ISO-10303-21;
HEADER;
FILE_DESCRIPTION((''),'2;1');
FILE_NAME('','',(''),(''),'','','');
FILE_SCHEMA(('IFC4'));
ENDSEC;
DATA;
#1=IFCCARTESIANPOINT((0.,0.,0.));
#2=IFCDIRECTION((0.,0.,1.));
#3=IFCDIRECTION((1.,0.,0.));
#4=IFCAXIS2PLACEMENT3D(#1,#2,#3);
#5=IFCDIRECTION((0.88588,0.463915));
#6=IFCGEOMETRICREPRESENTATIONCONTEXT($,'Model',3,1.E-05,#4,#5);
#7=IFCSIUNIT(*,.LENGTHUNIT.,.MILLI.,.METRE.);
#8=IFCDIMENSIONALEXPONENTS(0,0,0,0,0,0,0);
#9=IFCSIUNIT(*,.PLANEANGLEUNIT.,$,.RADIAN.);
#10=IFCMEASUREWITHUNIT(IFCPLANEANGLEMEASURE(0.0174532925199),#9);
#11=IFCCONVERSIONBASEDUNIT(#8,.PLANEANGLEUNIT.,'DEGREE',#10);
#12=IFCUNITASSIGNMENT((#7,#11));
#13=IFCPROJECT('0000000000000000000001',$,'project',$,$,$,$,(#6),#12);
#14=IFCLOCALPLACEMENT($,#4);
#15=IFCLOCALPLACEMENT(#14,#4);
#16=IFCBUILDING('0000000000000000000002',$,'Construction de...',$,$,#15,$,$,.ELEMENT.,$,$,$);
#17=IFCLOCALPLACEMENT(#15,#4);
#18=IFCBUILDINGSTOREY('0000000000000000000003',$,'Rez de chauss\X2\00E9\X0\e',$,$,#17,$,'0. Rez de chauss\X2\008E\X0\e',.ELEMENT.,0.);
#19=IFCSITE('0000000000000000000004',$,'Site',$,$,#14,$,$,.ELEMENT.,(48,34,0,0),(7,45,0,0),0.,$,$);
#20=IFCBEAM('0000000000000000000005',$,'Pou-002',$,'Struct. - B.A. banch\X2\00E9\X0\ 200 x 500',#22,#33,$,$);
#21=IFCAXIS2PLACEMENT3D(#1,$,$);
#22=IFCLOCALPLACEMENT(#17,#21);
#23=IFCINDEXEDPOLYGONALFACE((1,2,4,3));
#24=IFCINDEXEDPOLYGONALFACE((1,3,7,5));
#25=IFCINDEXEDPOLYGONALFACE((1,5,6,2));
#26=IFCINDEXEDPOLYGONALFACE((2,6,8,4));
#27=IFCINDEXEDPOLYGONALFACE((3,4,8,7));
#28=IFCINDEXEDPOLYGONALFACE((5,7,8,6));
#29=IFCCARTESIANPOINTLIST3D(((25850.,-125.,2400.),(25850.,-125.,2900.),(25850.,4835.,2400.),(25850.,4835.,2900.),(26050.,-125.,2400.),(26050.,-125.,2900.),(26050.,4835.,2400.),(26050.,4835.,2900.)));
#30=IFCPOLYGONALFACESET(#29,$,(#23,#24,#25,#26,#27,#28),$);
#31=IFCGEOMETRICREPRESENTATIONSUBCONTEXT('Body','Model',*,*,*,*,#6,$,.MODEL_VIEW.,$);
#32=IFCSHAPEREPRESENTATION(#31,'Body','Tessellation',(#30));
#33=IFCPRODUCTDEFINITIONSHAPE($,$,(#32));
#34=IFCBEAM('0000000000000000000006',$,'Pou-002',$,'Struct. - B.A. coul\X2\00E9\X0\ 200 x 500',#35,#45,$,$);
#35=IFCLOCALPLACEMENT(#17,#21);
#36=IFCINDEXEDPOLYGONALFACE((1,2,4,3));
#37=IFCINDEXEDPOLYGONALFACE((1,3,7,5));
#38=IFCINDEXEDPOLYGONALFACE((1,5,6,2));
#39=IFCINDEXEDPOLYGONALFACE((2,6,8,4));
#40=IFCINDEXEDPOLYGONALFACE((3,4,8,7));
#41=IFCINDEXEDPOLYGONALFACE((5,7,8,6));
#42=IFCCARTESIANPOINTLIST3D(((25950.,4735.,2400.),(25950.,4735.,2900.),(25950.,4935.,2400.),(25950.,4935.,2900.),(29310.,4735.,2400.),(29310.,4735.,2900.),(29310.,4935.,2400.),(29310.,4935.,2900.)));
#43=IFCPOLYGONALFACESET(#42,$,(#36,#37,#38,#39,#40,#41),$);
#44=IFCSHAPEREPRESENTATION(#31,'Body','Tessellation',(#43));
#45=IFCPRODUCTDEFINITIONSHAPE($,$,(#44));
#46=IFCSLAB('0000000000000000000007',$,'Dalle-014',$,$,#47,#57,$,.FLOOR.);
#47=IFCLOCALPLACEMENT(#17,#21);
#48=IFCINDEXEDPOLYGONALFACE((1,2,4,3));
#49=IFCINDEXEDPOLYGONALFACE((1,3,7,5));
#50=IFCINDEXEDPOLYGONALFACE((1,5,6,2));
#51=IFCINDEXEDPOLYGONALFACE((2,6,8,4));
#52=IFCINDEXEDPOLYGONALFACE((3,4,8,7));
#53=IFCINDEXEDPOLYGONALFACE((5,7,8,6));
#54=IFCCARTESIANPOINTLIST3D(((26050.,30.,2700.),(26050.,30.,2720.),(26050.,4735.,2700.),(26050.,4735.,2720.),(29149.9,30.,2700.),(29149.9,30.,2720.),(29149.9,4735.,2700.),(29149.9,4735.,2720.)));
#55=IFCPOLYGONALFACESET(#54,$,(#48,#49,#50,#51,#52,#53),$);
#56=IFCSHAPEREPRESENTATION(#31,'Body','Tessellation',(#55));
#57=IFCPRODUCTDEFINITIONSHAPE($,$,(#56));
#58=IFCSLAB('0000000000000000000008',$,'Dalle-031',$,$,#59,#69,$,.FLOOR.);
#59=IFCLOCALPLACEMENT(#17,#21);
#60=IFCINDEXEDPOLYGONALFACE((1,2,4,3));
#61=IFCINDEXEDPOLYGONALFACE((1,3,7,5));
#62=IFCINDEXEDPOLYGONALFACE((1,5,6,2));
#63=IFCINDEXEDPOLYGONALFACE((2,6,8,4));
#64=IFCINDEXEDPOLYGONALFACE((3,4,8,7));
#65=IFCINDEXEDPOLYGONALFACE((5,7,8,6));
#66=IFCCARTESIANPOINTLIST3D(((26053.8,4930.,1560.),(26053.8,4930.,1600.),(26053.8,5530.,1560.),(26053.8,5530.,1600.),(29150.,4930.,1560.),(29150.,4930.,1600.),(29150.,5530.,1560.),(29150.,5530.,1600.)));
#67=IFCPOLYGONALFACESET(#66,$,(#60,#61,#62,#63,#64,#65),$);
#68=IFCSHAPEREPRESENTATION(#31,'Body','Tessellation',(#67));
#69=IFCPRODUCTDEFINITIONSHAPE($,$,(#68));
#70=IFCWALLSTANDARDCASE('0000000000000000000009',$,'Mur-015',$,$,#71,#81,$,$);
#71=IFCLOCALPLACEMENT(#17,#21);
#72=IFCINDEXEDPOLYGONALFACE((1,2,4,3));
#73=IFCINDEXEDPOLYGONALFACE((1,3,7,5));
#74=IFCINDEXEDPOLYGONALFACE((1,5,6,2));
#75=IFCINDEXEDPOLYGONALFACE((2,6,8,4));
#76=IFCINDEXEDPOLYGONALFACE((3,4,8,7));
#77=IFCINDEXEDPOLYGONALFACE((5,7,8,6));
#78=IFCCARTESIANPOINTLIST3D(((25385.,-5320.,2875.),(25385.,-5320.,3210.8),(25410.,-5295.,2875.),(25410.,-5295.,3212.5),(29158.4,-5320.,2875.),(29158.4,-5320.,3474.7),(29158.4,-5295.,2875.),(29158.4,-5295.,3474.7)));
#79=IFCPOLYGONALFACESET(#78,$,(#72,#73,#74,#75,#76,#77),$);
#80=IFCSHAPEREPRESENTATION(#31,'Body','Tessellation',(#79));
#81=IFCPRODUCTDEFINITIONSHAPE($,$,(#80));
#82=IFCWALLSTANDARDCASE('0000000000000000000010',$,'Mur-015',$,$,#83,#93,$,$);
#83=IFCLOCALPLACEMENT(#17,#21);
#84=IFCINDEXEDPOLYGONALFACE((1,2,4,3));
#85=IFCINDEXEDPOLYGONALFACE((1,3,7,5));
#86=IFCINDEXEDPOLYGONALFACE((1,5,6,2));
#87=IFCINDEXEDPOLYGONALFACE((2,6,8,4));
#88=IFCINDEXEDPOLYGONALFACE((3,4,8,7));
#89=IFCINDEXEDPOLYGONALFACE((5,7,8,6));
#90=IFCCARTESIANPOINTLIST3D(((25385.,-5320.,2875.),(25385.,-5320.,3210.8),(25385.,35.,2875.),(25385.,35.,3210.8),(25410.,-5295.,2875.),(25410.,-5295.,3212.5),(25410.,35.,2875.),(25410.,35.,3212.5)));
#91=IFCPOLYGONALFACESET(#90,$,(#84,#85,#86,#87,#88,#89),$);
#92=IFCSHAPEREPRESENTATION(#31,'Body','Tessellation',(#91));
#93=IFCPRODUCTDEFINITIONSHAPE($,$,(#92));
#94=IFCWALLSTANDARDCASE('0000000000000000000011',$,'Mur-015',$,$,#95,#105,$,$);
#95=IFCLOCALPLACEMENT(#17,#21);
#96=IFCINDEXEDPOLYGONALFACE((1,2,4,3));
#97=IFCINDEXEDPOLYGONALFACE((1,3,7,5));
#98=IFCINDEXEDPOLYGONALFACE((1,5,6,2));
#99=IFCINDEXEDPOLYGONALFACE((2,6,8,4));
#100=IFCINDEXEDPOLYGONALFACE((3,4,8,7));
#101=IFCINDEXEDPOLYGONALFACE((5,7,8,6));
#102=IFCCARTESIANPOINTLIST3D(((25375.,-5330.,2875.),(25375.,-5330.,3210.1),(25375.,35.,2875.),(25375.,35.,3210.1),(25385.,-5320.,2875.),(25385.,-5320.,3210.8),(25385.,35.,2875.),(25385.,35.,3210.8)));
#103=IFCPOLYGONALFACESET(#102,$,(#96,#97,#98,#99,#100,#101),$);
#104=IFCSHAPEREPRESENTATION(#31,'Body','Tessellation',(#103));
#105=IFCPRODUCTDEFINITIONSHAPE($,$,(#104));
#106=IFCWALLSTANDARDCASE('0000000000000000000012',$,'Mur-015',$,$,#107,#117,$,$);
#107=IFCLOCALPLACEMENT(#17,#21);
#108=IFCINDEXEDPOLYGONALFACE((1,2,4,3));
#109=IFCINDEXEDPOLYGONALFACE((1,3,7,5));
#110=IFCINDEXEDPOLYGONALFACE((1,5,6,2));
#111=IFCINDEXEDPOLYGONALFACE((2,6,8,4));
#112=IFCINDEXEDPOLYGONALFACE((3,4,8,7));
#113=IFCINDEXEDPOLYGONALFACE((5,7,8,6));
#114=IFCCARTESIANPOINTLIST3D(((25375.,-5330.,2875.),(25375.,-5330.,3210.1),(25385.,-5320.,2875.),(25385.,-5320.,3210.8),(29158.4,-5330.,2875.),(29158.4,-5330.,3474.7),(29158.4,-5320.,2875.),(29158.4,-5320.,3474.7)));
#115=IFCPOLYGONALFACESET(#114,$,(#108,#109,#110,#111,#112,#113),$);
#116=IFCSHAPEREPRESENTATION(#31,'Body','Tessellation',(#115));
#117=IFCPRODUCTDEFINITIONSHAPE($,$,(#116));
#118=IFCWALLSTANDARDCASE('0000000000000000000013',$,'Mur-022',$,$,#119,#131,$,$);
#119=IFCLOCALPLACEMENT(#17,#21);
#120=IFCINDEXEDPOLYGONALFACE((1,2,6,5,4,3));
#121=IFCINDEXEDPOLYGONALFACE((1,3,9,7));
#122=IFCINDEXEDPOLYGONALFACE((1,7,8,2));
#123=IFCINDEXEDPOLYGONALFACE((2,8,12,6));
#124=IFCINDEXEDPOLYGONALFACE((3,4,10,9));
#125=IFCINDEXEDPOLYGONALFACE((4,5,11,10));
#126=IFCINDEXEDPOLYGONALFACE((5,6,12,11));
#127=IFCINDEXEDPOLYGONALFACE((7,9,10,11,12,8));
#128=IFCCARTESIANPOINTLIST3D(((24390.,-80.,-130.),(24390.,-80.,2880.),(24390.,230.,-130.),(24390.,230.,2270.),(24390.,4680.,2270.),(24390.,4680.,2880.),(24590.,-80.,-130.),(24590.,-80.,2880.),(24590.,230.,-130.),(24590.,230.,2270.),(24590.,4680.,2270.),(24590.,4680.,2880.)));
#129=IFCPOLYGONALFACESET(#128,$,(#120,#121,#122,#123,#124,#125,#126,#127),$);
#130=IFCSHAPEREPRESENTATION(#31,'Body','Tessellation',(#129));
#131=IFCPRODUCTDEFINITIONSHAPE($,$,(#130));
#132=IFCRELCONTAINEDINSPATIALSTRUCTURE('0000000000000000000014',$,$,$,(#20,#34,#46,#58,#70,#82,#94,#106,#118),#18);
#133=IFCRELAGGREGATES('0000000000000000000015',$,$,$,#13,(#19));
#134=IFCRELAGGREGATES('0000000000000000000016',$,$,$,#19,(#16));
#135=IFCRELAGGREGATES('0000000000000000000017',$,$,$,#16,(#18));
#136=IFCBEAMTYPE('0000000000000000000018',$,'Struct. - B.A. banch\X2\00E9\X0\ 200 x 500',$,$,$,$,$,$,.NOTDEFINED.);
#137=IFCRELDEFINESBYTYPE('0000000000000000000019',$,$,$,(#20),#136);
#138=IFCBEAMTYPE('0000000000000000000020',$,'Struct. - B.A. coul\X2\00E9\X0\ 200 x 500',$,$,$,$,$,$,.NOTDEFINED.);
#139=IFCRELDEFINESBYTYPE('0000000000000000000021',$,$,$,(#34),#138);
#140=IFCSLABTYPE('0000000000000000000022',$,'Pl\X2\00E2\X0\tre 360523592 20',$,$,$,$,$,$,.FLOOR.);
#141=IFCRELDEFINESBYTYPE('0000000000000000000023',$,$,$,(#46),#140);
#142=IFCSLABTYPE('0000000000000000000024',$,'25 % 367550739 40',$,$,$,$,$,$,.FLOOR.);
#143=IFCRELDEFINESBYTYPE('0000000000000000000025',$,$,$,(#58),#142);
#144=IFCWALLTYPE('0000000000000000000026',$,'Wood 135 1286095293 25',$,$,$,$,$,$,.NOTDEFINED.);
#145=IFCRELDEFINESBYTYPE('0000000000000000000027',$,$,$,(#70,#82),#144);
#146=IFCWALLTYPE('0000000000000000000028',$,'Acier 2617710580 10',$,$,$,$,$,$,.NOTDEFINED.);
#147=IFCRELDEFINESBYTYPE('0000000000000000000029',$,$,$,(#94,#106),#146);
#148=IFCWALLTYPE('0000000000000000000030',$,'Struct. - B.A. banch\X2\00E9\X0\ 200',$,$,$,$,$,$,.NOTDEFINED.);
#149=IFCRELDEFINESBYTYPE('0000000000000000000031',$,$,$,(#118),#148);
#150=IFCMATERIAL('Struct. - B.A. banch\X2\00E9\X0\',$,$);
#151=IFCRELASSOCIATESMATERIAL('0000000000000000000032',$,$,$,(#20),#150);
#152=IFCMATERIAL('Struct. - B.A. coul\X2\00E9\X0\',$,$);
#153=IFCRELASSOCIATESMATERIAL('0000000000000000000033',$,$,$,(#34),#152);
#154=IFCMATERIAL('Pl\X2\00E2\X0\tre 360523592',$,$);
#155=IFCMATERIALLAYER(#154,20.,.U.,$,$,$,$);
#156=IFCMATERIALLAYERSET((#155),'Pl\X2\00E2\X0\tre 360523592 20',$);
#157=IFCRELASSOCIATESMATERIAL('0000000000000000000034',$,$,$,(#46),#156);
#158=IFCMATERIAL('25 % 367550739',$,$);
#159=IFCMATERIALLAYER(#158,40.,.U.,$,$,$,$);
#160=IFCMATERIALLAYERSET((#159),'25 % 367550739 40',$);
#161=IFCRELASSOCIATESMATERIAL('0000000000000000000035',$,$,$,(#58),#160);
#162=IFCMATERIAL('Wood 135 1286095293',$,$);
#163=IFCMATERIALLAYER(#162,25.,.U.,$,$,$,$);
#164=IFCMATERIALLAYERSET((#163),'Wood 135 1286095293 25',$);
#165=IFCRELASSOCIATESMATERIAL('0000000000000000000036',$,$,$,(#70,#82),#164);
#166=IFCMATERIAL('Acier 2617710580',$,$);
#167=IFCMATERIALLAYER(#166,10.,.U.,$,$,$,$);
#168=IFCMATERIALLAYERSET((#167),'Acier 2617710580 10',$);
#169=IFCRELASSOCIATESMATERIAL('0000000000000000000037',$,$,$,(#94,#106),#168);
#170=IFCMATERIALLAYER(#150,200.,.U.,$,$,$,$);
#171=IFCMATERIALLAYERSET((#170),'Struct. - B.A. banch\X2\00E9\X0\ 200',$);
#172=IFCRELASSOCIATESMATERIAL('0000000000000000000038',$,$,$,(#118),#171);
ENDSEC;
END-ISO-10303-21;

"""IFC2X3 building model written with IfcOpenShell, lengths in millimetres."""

from ifc_helpers import new_model, entity, si_unit, converted_unit, direction, frame, frame_2d, origin_with_axes, origin_2d_with_axis, place, context, subcontext, project, spatial, polyline, rectangle, outline, extrude, clip, halfspace, material, layer, layer_set, layer_usage, type_object, element, save


model = new_model("IFC2X3")

# Units and contexts
model_context = context("Model", 3, precision=1e-05, world=origin_with_axes(), true_north=direction((0.88588, 0.463915)))
body_context = subcontext(model_context, "Body", "Model", "MODEL_VIEW")
ifc_project = project(units=[si_unit("LENGTHUNIT", "METRE", prefix="MILLI"), converted_unit("PLANEANGLEUNIT", "DEGREE", entity("IfcPlaneAngleMeasure", 0.0174532925199), si_unit("PLANEANGLEUNIT", "RADIAN"), dimensions=[0, 0, 0, 0, 0, 0, 0])], contexts=[model_context])

# Site, building, storey
site_placement = place(None, origin_with_axes())
site = spatial("IfcSite", under=ifc_project, at=site_placement, Name="Site", CompositionType="ELEMENT", RefLatitude=(48, 34, 0, 0), RefLongitude=(7, 45, 0, 0), RefElevation=0.0)
building_placement = place(site_placement, origin_with_axes())
building = spatial("IfcBuilding", under=site, at=building_placement, Name="Construction de...", CompositionType="ELEMENT")
storey_placement = place(building_placement, origin_with_axes())
storey = spatial("IfcBuildingStorey", under=building, at=storey_placement, Name="Rez de chaussée", LongName="0. Rez de chauss\u008ee", CompositionType="ELEMENT", Elevation=0.0)

# Beams
ifc_material_1 = material(Name="Struct. - B.A. banché")
beam_type_1 = type_object("IfcBeamType", Name="Struct. - B.A. banché 200 x 500", PredefinedType="NOTDEFINED")
beam_1_placement = place(storey_placement, frame((25950.0, 4835.0, 2900.0), z_axis=(0.0, 0.0, 1.0), x_axis=(-1.0, 0.0, 0.0)))
element("IfcBeam", 1, at=beam_1_placement, inside=storey, type_object=beam_type_1, material=ifc_material_1, Name="Pou-002", ObjectType="Struct. - B.A. banché 200 x 500", context=body_context, shape_type="SweptSolid", body=[
    extrude(rectangle(XDim=500.0, YDim=200.0, at=frame_2d((-250.0, 0.0), x_axis=(1.0, 0.0))), frame((0.0, 0.0, 0.0), z_axis=(0.0, 1.0, 0.0), x_axis=(0.0, 0.0, 1.0)), (0.0, 0.0, 1.0), 4960.0),
])
ifc_material_2 = material(Name="Struct. - B.A. coulé")
beam_type_2 = type_object("IfcBeamType", Name="Struct. - B.A. coulé 200 x 500", PredefinedType="NOTDEFINED")
beam_2_placement = place(storey_placement, frame((25950.0, 4835.0, 2900.0), z_axis=(0.0, 0.0, 1.0), x_axis=(0.0, -1.0, 0.0)))
element("IfcBeam", 2, at=beam_2_placement, inside=storey, type_object=beam_type_2, material=ifc_material_2, Name="Pou-002", ObjectType="Struct. - B.A. coulé 200 x 500", context=body_context, shape_type="SweptSolid", body=[
    extrude(rectangle(XDim=500.0, YDim=200.0, at=frame_2d((-250.0, 0.0), x_axis=(1.0, 0.0))), frame((0.0, 0.0, 0.0), z_axis=(0.0, 1.0, 0.0), x_axis=(0.0, 0.0, 1.0)), (0.0, 0.0, 1.0), 3360.0),
])

# Slabs
ifc_material_3 = material(Name="Plâtre 360523592")
ifc_layer_1 = layer(ifc_material_3, 20.0, ventilated="UNKNOWN")
ifc_layer_set_1 = layer_set([ifc_layer_1], Name="Plâtre 360523592 20")
ifc_layer_usage_1 = layer_usage(ifc_layer_set_1, "AXIS3", "NEGATIVE", 20.0)
slab_type_1 = type_object("IfcSlabType", Name="Plâtre 360523592 20", PredefinedType="FLOOR")
slab_1_placement = place(storey_placement, frame((26050.0, 4735.0, 2720.0), z_axis=(0.0, 0.0, 1.0), x_axis=(1.0, 0.0, 0.0)))
element("IfcSlab", 3, at=slab_1_placement, inside=storey, type_object=slab_type_1, material=ifc_layer_usage_1, Name="Dalle-014", PredefinedType="FLOOR", context=body_context, shape_type="SweptSolid", body=[
    extrude(outline(polyline([(0.0, 0.0), (0.0, -4705.0), (3099.9, -4705.0), (3099.9, 0.0), (0.0, 0.0)])), frame((0.0, 0.0, -20.0), z_axis=(0.0, 0.0, 1.0), x_axis=(1.0, 0.0, 0.0)), (0.0, 0.0, 1.0), 20.0),
])
ifc_material_4 = material(Name="25 % 367550739")
ifc_layer_2 = layer(ifc_material_4, 40.0, ventilated="UNKNOWN")
ifc_layer_set_2 = layer_set([ifc_layer_2], Name="25 % 367550739 40")
ifc_layer_usage_2 = layer_usage(ifc_layer_set_2, "AXIS3", "NEGATIVE", 40.0)
slab_type_2 = type_object("IfcSlabType", Name="25 % 367550739 40", PredefinedType="FLOOR")
slab_2_placement = place(storey_placement, frame((26053.8, 5530.0, 1600.0), z_axis=(0.0, 0.0, 1.0), x_axis=(1.0, 0.0, 0.0)))
element("IfcSlab", 4, at=slab_2_placement, inside=storey, type_object=slab_type_2, material=ifc_layer_usage_2, Name="Dalle-031", PredefinedType="FLOOR", context=body_context, shape_type="SweptSolid", body=[
    extrude(outline(polyline([(0.0, 0.0), (0.0, -600.0), (3096.2, -600.0), (3096.2, 0.0), (0.0, 0.0)])), frame((0.0, 0.0, -40.0), z_axis=(0.0, 0.0, 1.0), x_axis=(1.0, 0.0, 0.0)), (0.0, 0.0, 1.0), 40.0),
])

# Walls
ifc_material_5 = material(Name="Wood 135 1286095293")
ifc_layer_3 = layer(ifc_material_5, 25.0, ventilated="UNKNOWN")
ifc_layer_set_3 = layer_set([ifc_layer_3], Name="Wood 135 1286095293 25")
ifc_layer_usage_3 = layer_usage(ifc_layer_set_3, "AXIS2", "NEGATIVE", 12.5)
wall_type_1 = type_object("IfcWallType", Name="Wood 135 1286095293 25", PredefinedType="NOTDEFINED")
wall_1_placement = place(storey_placement, frame((25397.5, -5307.5, 2875.0), z_axis=(0.0, 0.0, 1.0), x_axis=(1.0, 0.0, 0.0)))
element("IfcWallStandardCase", 5, at=wall_1_placement, inside=storey, type_object=wall_type_1, material=ifc_layer_usage_3, Name="Mur-015", context=body_context, shape_type="Clipping", body=[
    clip(extrude(outline(polyline([(-12.5, -12.5), (3760.9, -12.5), (3760.9, 12.5), (12.5, 12.5), (-12.5, -12.5)])), origin_with_axes(), (0.0, 0.0, 1.0), 600.0), halfspace(frame((-23.4, 0.0, 335.0), z_axis=(0.069756, 0.0, -0.997564), x_axis=(0.0, 1.0, 0.0)), True)),
])
ifc_layer_usage_4 = layer_usage(ifc_layer_set_3, "AXIS2", "NEGATIVE", 12.5)
wall_2_placement = place(storey_placement, frame((25397.5, -5307.5, 2875.0), z_axis=(0.0, 0.0, 1.0), x_axis=(0.0, 1.0, 0.0)))
element("IfcWallStandardCase", 6, at=wall_2_placement, inside=storey, type_object=wall_type_1, material=ifc_layer_usage_4, Name="Mur-015", context=body_context, shape_type="Clipping", body=[
    clip(extrude(outline(polyline([(12.5, -12.5), (5342.5, -12.5), (5342.5, 12.5), (-12.5, 12.5), (12.5, -12.5)])), origin_with_axes(), (0.0, 0.0, 1.0), 625.0), halfspace(frame((0.0, 23.4, 335.0), z_axis=(0.0, -0.069756, -0.997564), x_axis=(0.0, 0.997564, -0.069756)), True)),
])
ifc_material_6 = material(Name="Acier 2617710580")
ifc_layer_4 = layer(ifc_material_6, 10.0, ventilated="UNKNOWN")
ifc_layer_set_4 = layer_set([ifc_layer_4], Name="Acier 2617710580 10")
ifc_layer_usage_5 = layer_usage(ifc_layer_set_4, "AXIS2", "NEGATIVE", 5.0)
wall_type_2 = type_object("IfcWallType", Name="Acier 2617710580 10", PredefinedType="NOTDEFINED")
wall_3_placement = place(storey_placement, frame((25380.0, -5325.0, 2875.0), z_axis=(0.0, 0.0, 1.0), x_axis=(0.0, 1.0, 0.0)))
element("IfcWallStandardCase", 7, at=wall_3_placement, inside=storey, type_object=wall_type_2, material=ifc_layer_usage_5, Name="Mur-015", context=body_context, shape_type="Clipping", body=[
    clip(extrude(outline(polyline([(5.0, -5.0), (5360.0, -5.0), (5360.0, 5.0), (-5.0, 5.0), (5.0, -5.0)])), origin_with_axes(), (0.0, 0.0, 1.0), 625.0), halfspace(frame((0.0, 23.3, 333.8), z_axis=(0.0, -0.069756, -0.997564), x_axis=(0.0, 0.997564, -0.069756)), True)),
])
ifc_layer_usage_6 = layer_usage(ifc_layer_set_4, "AXIS2", "NEGATIVE", 5.0)
wall_4_placement = place(storey_placement, frame((25380.0, -5325.0, 2875.0), z_axis=(0.0, 0.0, 1.0), x_axis=(1.0, 0.0, 0.0)))
element("IfcWallStandardCase", 8, at=wall_4_placement, inside=storey, type_object=wall_type_2, material=ifc_layer_usage_6, Name="Mur-015", context=body_context, shape_type="Clipping", body=[
    clip(extrude(outline(polyline([(-5.0, -5.0), (3778.4, -5.0), (3778.4, 5.0), (5.0, 5.0), (-5.0, -5.0)])), origin_with_axes(), (0.0, 0.0, 1.0), 625.0), halfspace(frame((-23.3, 0.0, 333.8), z_axis=(0.069756, 0.0, -0.997564), x_axis=(0.0, 1.0, 0.0)), True)),
])

# Wall, opening
ifc_layer_5 = layer(ifc_material_1, 200.0, ventilated="UNKNOWN")
ifc_layer_set_5 = layer_set([ifc_layer_5], Name="Struct. - B.A. banché 200")
ifc_layer_usage_7 = layer_usage(ifc_layer_set_5, "AXIS2", "POSITIVE", -100.0)
wall_type_3 = type_object("IfcWallType", Name="Struct. - B.A. banché 200", PredefinedType="NOTDEFINED")
wall_5_placement = place(storey_placement, frame((24490.0, 4680.0, -130.0), z_axis=(0.0, 0.0, 1.0), x_axis=(0.0, -1.0, 0.0)))
wall_5 = element("IfcWallStandardCase", 9, at=wall_5_placement, inside=storey, type_object=wall_type_3, material=ifc_layer_usage_7, Name="Mur-022", context=body_context, shape_type="SweptSolid", body=[
    extrude(outline(polyline([(0.0, -100.0), (4760.0, -100.0), (4760.0, 100.0), (0.0, 100.0), (0.0, -100.0)])), origin_with_axes(), (0.0, 0.0, 1.0), 3010.0),
])
opening_1_placement = place(wall_5_placement, frame((2225.0, 0.0, 0.0), z_axis=(0.0, 0.0, 1.0), x_axis=(1.0, 0.0, 0.0)))
element("IfcOpeningElement", 10, at=opening_1_placement, cuts=wall_5, context=body_context, shape_type="SweptSolid", body=[
    extrude(rectangle(XDim=4450.0, YDim=2400.0, at=origin_2d_with_axis()), frame((0.0, -100.0, 1200.0), z_axis=(0.0, 1.0, 0.0), x_axis=(1.0, 0.0, 0.0)), (0.0, 0.0, -1.0), 200.0),
    extrude(rectangle(XDim=4450.0, YDim=2400.0, at=origin_2d_with_axis()), frame((0.0, -100.0, 1200.0), z_axis=(0.0, -1.0, 0.0), x_axis=(1.0, 0.0, 0.0)), (0.0, 0.0, -1.0), 200.0),
])

save(model, "model.ifc")
